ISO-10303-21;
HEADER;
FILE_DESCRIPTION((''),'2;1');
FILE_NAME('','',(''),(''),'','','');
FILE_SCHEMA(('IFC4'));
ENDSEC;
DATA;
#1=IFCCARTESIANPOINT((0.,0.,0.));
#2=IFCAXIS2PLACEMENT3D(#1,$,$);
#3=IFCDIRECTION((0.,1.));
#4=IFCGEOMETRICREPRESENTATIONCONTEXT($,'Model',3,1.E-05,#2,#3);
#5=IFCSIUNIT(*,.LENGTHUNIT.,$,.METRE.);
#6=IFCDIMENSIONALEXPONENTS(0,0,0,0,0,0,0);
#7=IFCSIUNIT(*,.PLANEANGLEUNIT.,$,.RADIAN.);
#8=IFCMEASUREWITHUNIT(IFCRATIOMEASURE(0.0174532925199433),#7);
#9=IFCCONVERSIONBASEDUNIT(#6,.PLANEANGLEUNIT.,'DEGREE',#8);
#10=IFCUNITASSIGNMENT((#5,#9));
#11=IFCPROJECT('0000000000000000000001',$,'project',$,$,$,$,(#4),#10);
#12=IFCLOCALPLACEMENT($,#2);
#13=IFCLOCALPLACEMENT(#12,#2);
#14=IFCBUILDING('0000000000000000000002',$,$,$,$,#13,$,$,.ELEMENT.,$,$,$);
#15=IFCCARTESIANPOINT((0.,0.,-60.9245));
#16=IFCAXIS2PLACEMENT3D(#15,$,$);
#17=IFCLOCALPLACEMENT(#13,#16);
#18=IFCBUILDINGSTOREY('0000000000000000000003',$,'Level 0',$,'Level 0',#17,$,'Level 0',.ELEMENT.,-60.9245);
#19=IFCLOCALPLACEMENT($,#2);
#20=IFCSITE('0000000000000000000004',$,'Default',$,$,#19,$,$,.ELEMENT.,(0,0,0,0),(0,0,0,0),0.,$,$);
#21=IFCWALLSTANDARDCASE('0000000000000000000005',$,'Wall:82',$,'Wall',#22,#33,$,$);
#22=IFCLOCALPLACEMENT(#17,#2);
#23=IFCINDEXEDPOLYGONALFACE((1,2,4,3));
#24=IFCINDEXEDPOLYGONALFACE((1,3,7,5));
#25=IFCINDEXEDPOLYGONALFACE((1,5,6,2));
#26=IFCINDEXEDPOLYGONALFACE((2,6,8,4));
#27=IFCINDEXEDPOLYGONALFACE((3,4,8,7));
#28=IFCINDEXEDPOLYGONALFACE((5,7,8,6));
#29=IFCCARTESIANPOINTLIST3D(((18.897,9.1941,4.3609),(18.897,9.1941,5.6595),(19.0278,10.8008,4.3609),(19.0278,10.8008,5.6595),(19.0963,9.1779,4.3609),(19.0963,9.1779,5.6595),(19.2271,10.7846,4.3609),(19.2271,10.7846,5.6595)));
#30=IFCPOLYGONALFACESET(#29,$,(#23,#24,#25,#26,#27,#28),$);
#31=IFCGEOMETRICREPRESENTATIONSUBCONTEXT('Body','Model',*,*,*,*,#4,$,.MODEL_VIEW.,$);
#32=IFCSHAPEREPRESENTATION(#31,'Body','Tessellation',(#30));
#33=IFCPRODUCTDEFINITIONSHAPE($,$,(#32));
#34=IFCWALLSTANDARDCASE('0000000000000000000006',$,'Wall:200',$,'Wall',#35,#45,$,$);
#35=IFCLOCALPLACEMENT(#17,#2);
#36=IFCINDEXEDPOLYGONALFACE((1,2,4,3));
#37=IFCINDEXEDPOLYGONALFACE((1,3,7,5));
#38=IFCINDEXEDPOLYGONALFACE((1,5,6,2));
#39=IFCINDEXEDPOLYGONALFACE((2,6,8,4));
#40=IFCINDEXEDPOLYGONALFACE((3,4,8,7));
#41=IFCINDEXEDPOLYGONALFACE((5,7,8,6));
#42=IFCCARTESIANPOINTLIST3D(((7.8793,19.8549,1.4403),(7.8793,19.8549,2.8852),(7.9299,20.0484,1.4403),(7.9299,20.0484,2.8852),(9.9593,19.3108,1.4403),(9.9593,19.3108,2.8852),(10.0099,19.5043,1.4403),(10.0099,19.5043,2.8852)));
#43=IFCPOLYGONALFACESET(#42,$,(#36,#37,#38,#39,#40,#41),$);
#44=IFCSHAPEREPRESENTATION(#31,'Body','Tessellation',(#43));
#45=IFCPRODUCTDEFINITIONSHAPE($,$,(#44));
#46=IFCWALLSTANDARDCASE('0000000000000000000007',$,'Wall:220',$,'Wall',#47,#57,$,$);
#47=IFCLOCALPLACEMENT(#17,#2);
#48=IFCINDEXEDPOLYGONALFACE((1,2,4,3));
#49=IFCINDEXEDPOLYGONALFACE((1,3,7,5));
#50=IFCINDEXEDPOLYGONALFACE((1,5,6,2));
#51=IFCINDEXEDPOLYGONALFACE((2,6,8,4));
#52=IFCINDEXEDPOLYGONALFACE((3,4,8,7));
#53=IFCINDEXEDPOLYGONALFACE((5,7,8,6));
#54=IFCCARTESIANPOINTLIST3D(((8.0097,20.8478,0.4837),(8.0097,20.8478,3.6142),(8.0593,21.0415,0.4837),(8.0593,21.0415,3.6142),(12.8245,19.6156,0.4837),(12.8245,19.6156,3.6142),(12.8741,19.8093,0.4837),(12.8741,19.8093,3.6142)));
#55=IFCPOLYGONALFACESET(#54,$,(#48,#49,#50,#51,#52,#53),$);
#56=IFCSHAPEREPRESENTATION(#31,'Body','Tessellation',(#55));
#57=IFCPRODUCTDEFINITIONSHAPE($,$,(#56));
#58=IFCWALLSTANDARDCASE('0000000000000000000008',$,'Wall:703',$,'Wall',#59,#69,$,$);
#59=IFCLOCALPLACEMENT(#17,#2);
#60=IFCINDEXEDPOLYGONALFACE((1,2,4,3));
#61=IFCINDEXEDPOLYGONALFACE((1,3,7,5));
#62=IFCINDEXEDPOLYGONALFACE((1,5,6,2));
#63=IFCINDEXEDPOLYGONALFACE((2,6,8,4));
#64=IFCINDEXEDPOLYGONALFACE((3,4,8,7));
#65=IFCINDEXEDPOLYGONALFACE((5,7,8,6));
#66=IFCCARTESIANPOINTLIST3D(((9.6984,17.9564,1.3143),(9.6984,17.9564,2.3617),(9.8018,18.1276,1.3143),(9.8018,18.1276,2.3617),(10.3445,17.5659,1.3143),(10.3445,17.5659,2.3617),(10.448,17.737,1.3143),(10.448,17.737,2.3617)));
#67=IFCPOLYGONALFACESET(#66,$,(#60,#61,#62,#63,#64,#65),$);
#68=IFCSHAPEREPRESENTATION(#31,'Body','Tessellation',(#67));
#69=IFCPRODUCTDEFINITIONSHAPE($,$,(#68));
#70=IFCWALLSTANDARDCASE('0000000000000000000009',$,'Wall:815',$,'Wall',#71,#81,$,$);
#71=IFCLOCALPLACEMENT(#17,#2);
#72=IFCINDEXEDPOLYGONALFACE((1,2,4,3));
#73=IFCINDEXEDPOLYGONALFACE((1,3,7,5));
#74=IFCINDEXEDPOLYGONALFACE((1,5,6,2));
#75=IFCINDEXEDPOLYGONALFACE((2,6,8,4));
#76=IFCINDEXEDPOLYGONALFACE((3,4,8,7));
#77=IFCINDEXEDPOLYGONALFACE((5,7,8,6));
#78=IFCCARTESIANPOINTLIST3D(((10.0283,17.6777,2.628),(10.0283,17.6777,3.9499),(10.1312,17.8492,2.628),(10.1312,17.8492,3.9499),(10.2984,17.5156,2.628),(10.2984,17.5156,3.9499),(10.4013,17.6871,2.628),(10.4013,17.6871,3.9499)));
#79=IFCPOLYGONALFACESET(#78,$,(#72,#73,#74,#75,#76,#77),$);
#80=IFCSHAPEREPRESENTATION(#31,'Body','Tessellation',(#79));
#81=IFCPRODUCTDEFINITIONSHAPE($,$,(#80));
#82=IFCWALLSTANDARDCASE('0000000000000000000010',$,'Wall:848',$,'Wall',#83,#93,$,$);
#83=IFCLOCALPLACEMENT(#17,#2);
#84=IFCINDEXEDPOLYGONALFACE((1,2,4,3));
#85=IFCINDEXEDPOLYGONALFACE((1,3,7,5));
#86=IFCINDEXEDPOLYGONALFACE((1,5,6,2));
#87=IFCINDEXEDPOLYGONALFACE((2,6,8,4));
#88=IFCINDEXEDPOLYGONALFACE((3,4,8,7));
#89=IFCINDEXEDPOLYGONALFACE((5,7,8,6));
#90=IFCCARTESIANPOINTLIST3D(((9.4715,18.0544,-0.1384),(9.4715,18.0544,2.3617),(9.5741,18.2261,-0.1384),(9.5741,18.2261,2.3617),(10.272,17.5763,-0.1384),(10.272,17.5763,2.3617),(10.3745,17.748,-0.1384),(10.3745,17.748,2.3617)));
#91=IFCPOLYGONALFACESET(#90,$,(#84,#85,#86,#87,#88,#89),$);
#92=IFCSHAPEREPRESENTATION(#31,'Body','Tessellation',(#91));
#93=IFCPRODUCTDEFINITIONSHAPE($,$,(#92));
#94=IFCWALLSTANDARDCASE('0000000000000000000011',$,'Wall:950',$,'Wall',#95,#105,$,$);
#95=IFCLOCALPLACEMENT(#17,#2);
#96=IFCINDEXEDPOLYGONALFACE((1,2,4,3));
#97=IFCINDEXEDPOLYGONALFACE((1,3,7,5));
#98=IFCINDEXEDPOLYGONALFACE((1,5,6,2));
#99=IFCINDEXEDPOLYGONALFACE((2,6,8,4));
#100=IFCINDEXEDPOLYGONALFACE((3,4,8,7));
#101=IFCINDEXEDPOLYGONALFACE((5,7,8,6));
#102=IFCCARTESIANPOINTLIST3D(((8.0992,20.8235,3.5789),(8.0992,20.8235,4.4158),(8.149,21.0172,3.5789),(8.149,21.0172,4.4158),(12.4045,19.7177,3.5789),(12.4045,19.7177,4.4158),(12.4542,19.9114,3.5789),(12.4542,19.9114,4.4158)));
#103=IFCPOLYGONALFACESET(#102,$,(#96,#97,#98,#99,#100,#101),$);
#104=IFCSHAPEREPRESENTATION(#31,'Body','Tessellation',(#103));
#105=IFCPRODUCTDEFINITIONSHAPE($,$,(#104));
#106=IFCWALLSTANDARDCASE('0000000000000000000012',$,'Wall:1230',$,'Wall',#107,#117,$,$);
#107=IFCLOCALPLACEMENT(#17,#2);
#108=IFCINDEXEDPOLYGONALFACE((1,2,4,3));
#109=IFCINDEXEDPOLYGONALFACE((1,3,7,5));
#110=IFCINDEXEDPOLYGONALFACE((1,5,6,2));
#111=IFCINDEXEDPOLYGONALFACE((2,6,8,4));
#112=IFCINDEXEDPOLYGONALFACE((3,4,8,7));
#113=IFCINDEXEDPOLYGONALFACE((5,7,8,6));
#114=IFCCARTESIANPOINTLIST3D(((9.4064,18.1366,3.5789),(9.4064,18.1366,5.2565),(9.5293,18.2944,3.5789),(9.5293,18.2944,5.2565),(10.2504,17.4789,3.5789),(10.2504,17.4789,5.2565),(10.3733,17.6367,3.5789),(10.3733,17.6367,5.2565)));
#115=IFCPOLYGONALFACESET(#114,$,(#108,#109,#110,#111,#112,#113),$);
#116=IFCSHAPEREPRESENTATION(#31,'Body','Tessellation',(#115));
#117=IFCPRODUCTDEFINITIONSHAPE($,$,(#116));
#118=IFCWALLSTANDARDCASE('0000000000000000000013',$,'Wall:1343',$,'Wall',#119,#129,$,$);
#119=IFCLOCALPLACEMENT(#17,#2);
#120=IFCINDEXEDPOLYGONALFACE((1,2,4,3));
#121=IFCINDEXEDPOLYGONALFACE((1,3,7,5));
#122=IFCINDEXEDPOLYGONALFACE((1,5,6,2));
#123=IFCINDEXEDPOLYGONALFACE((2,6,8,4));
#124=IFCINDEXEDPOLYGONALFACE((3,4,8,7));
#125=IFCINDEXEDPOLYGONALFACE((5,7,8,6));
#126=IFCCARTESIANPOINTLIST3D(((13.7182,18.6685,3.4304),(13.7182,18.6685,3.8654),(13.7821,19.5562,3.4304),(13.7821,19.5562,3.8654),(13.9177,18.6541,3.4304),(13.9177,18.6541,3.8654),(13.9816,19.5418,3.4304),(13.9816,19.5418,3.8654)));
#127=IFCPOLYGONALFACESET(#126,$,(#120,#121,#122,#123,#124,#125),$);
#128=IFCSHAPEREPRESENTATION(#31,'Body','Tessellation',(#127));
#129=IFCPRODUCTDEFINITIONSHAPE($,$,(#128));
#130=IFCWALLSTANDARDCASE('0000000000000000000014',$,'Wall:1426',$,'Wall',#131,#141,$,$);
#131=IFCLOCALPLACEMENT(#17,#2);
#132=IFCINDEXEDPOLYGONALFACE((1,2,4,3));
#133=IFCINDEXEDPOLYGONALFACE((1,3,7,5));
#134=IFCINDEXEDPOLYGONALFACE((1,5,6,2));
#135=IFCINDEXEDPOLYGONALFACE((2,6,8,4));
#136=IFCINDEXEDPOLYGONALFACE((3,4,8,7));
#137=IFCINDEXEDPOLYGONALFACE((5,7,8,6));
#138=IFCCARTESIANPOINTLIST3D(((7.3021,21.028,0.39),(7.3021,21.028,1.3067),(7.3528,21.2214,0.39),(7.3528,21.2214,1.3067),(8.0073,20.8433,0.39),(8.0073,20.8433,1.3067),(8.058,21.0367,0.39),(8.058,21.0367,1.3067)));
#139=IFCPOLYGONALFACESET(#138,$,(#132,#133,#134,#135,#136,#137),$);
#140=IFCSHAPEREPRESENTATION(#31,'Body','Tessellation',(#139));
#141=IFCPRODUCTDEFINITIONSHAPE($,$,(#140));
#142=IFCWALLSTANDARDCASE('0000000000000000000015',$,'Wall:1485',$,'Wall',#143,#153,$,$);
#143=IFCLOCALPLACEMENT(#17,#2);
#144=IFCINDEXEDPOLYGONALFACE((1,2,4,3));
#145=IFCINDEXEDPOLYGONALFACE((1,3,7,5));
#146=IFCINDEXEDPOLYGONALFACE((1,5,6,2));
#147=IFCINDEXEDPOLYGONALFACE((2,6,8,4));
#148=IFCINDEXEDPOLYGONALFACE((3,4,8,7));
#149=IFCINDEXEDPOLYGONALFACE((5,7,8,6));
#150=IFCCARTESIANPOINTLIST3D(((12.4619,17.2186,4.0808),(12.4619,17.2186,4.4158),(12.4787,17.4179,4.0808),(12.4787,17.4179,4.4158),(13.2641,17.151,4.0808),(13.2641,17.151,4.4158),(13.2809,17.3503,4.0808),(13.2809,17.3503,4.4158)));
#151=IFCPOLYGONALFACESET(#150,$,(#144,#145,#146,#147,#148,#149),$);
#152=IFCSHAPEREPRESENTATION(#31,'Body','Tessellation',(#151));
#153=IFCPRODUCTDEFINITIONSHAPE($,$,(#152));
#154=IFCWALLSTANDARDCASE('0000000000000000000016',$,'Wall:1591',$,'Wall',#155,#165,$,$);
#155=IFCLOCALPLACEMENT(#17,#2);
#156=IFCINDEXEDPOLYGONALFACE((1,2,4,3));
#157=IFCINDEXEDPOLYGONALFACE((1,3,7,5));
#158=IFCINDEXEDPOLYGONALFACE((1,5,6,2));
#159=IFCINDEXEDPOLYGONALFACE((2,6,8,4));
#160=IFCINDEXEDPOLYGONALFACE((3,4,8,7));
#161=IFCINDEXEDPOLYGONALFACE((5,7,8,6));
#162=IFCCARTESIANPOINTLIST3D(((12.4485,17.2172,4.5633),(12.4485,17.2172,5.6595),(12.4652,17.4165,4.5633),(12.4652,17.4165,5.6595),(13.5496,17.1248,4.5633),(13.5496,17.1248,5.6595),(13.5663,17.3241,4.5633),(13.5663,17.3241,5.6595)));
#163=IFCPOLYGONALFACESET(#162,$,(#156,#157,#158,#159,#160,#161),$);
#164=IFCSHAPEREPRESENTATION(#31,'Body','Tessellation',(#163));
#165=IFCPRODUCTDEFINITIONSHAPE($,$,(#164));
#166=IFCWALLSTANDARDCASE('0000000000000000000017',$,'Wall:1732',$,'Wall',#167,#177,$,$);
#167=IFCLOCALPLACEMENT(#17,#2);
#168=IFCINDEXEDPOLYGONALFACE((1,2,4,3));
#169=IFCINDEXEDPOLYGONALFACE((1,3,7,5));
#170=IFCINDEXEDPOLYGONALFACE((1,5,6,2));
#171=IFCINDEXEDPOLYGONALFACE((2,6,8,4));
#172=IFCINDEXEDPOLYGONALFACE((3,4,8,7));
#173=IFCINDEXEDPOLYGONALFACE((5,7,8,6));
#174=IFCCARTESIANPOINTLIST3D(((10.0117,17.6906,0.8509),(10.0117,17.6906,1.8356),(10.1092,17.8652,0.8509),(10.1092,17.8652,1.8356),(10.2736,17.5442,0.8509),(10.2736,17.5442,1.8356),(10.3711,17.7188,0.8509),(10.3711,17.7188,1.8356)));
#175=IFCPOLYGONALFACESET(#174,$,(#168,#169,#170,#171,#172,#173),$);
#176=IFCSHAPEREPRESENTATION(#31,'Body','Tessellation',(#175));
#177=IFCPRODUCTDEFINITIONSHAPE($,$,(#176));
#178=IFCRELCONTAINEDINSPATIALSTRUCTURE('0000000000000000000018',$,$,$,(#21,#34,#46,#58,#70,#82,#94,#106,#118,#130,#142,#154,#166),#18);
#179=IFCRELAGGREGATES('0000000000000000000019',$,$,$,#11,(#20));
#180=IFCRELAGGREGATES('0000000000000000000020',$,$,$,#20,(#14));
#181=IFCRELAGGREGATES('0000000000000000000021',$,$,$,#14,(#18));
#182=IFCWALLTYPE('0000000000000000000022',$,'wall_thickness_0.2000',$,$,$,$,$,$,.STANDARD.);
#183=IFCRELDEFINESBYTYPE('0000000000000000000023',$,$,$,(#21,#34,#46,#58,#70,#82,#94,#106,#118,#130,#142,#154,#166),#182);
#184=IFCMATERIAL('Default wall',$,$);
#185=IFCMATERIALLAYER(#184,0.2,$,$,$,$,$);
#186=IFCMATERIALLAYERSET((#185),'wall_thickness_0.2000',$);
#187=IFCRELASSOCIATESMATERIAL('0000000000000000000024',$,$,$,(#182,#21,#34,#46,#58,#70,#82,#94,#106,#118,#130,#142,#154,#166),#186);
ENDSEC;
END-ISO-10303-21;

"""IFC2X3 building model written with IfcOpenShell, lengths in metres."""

from ifc_helpers import new_model, entity, si_unit, converted_unit, direction, frame, origin, place, context, subcontext, project, spatial, polyline, outline, extrude, material, layer, layer_set, layer_usage, type_object, element, save


model = new_model("IFC2X3")

# Units and contexts
model_context = context("Model", 3, precision=1e-05, world=origin(), true_north=direction((0.0, 1.0)))
body_context = subcontext(model_context, "Body", "Model", "MODEL_VIEW")
ifc_project = project(units=[si_unit("LENGTHUNIT", "METRE"), converted_unit("PLANEANGLEUNIT", "DEGREE", entity("IfcRatioMeasure", 0.0174532925199433), si_unit("PLANEANGLEUNIT", "RADIAN"), dimensions=[0, 0, 0, 0, 0, 0, 0])], contexts=[model_context])

# Site, building, storey
site_placement = place(None, origin())
site = spatial("IfcSite", under=ifc_project, at=site_placement, Name="Default", CompositionType="ELEMENT", RefLatitude=(0, 0, 0, 0), RefLongitude=(0, 0, 0, 0), RefElevation=0.0)
placement_1 = place(None, origin())
building_placement = place(placement_1, origin())
building = spatial("IfcBuilding", under=site, at=building_placement, CompositionType="ELEMENT")
storey_placement = place(building_placement, frame((0.0, 0.0, -60.9245)))
storey = spatial("IfcBuildingStorey", under=building, at=storey_placement, Name="Level 0", ObjectType="Level 0", LongName="Level 0", CompositionType="ELEMENT", Elevation=-60.9245)

# Walls
ifc_material = material(Name="Default wall")
ifc_layer = layer(ifc_material, 0.2)
ifc_layer_set = layer_set([ifc_layer], Name="wall_thickness_0.2000")
ifc_layer_usage = layer_usage(ifc_layer_set, "AXIS2", "POSITIVE", -0.1)
wall_type = type_object("IfcWallType", Name="wall_thickness_0.2000", PredefinedType="STANDARD", material=ifc_layer_set)
placement_2 = place(building_placement, frame((0.0, 0.0, -56.5636)))
wall_1_placement = place(placement_2, frame((19.1274, 10.7927, 0.0), z_axis=(0.0, 0.0, 1.0), x_axis=(-0.081124, -0.996704, 0.0)))
element("IfcWallStandardCase", 1, at=wall_1_placement, inside=storey, type_object=wall_type, material=ifc_layer_usage, Name="Wall:82", ObjectType="Wall", context=body_context, shape_type="SweptSolid", body=[
    extrude(outline(polyline([(1.612, -0.1), (1.612, 0.1), (0.0, 0.1), (0.0, -0.1), (1.612, -0.1)])), origin(), (0.0, 0.0, 1.0), 1.2985),
])
placement_3 = place(building_placement, frame((0.0, 0.0, -59.4842)))
wall_2_placement = place(placement_3, frame((7.9046, 19.9517, 0.0), z_axis=(0.0, 0.0, 1.0), x_axis=(0.96744, -0.253101, 0.0)))
element("IfcWallStandardCase", 2, at=wall_2_placement, inside=storey, type_object=wall_type, material=ifc_layer_usage, Name="Wall:200", ObjectType="Wall", context=body_context, shape_type="SweptSolid", body=[
    extrude(outline(polyline([(2.15, -0.1), (2.15, 0.1), (0.0, 0.1), (0.0, -0.1), (2.15, -0.1)])), origin(), (0.0, 0.0, 1.0), 1.4449),
])
placement_4 = place(building_placement, frame((0.0, 0.0, -60.4408)))
wall_3_placement = place(placement_4, frame((8.0345, 20.9446, 0.0), z_axis=(0.0, 0.0, 1.0), x_axis=(0.96878, -0.247923, 0.0)))
element("IfcWallStandardCase", 3, at=wall_3_placement, inside=storey, type_object=wall_type, material=ifc_layer_usage, Name="Wall:220", ObjectType="Wall", context=body_context, shape_type="SweptSolid", body=[
    extrude(outline(polyline([(4.97, -0.1), (4.97, 0.1), (0.0, 0.1), (0.0, -0.1), (4.97, -0.1)])), origin(), (0.0, 0.0, 1.0), 3.1305),
])
placement_5 = place(building_placement, frame((0.0, 0.0, -59.6102)))
wall_4_placement = place(placement_5, frame((10.3963, 17.6515, 0.0), z_axis=(0.0, 0.0, 1.0), x_axis=(-0.85584, 0.51724, 0.0)))
element("IfcWallStandardCase", 4, at=wall_4_placement, inside=storey, type_object=wall_type, material=ifc_layer_usage, Name="Wall:703", ObjectType="Wall", context=body_context, shape_type="SweptSolid", body=[
    extrude(outline(polyline([(0.755, -0.1), (0.755, 0.1), (0.0, 0.1), (0.0, -0.1), (0.755, -0.1)])), origin(), (0.0, 0.0, 1.0), 1.0474),
])
placement_6 = place(building_placement, frame((0.0, 0.0, -58.2965)))
wall_5_placement = place(placement_6, frame((10.3499, 17.6013, 0.0), z_axis=(0.0, 0.0, 1.0), x_axis=(-0.857418, 0.514621, 0.0)))
element("IfcWallStandardCase", 5, at=wall_5_placement, inside=storey, type_object=wall_type, material=ifc_layer_usage, Name="Wall:815", ObjectType="Wall", context=body_context, shape_type="SweptSolid", body=[
    extrude(outline(polyline([(0.315, -0.1), (0.315, 0.1), (0.0, 0.1), (0.0, -0.1), (0.315, -0.1)])), origin(), (0.0, 0.0, 1.0), 1.3219),
])
placement_7 = place(building_placement, frame((0.0, 0.0, -61.0629)))
wall_6_placement = place(placement_7, frame((10.3233, 17.6621, 0.0), z_axis=(0.0, 0.0, 1.0), x_axis=(-0.858516, 0.512787, 0.0)))
element("IfcWallStandardCase", 6, at=wall_6_placement, inside=storey, type_object=wall_type, material=ifc_layer_usage, Name="Wall:848", ObjectType="Wall", context=body_context, shape_type="SweptSolid", body=[
    extrude(outline(polyline([(0.9324, -0.1), (0.9324, 0.1), (0.0, 0.1), (0.0, -0.1), (0.9324, -0.1)])), origin(), (0.0, 0.0, 1.0), 2.5001),
])
placement_8 = place(building_placement, frame((0.0, 0.0, -57.3456)))
wall_7_placement = place(placement_8, frame((8.1241, 20.9204, 0.0), z_axis=(0.0, 0.0, 1.0), x_axis=(0.968563, -0.248767, 0.0)))
element("IfcWallStandardCase", 7, at=wall_7_placement, inside=storey, type_object=wall_type, material=ifc_layer_usage, Name="Wall:950", ObjectType="Wall", context=body_context, shape_type="SweptSolid", body=[
    extrude(outline(polyline([(4.445, -0.1), (4.445, 0.1), (0.0, 0.1), (0.0, -0.1), (4.445, -0.1)])), origin(), (0.0, 0.0, 1.0), 0.8369),
])
placement_9 = place(building_placement, frame((0.0, 0.0, -57.3456)))
wall_8_placement = place(placement_9, frame((10.3119, 17.5578, 0.0), z_axis=(0.0, 0.0, 1.0), x_axis=(-0.78878, 0.614676, 0.0)))
element("IfcWallStandardCase", 8, at=wall_8_placement, inside=storey, type_object=wall_type, material=ifc_layer_usage, Name="Wall:1230", ObjectType="Wall", context=body_context, shape_type="SweptSolid", body=[
    extrude(outline(polyline([(1.07, -0.1), (1.07, 0.1), (0.0, 0.1), (0.0, -0.1), (1.07, -0.1)])), origin(), (0.0, 0.0, 1.0), 1.6776),
])
placement_10 = place(building_placement, frame((0.0, 0.0, -57.4941)))
wall_9_placement = place(placement_10, frame((13.8179, 18.6613, 0.0), z_axis=(0.0, 0.0, 1.0), x_axis=(0.071858, 0.997415, 0.0)))
element("IfcWallStandardCase", 9, at=wall_9_placement, inside=storey, type_object=wall_type, material=ifc_layer_usage, Name="Wall:1343", ObjectType="Wall", context=body_context, shape_type="SweptSolid", body=[
    extrude(outline(polyline([(0.89, -0.1), (0.89, 0.1), (0.0, 0.1), (0.0, -0.1), (0.89, -0.1)])), origin(), (0.0, 0.0, 1.0), 0.435),
])
placement_11 = place(building_placement, frame((0.0, 0.0, -60.5345)))
wall_10_placement = place(placement_11, frame((7.3274, 21.1247, 0.0), z_axis=(0.0, 0.0, 1.0), x_axis=(0.967376, -0.253345, 0.0)))
element("IfcWallStandardCase", 10, at=wall_10_placement, inside=storey, type_object=wall_type, material=ifc_layer_usage, Name="Wall:1426", ObjectType="Wall", context=body_context, shape_type="SweptSolid", body=[
    extrude(outline(polyline([(0.729, -0.1), (0.729, 0.1), (0.0, 0.1), (0.0, -0.1), (0.729, -0.1)])), origin(), (0.0, 0.0, 1.0), 0.9167),
])
placement_12 = place(building_placement, frame((0.0, 0.0, -56.8437)))
wall_11_placement = place(placement_12, frame((12.4703, 17.3183, 0.0), z_axis=(0.0, 0.0, 1.0), x_axis=(0.996465, -0.084013, 0.0)))
element("IfcWallStandardCase", 11, at=wall_11_placement, inside=storey, type_object=wall_type, material=ifc_layer_usage, Name="Wall:1485", ObjectType="Wall", context=body_context, shape_type="SweptSolid", body=[
    extrude(outline(polyline([(0.805, -0.1), (0.805, 0.1), (0.0, 0.1), (0.0, -0.1), (0.805, -0.1)])), origin(), (0.0, 0.0, 1.0), 0.335),
])
placement_13 = place(building_placement, frame((0.0, 0.0, -56.3612)))
wall_12_placement = place(placement_13, frame((13.558, 17.2244, 0.0), z_axis=(0.0, 0.0, 1.0), x_axis=(-0.996492, 0.083687, 0.0)))
element("IfcWallStandardCase", 12, at=wall_12_placement, inside=storey, type_object=wall_type, material=ifc_layer_usage, Name="Wall:1591", ObjectType="Wall", context=body_context, shape_type="SweptSolid", body=[
    extrude(outline(polyline([(1.105, -0.1), (1.105, 0.1), (0.0, 0.1), (0.0, -0.1), (1.105, -0.1)])), origin(), (0.0, 0.0, 1.0), 1.0962),
])
placement_14 = place(building_placement, frame((0.0, 0.0, -60.0736)))
wall_13_placement = place(placement_14, frame((10.3224, 17.6315, 0.0), z_axis=(0.0, 0.0, 1.0), x_axis=(-0.872981, 0.487754, 0.0)))
element("IfcWallStandardCase", 13, at=wall_13_placement, inside=storey, type_object=wall_type, material=ifc_layer_usage, Name="Wall:1732", ObjectType="Wall", context=body_context, shape_type="SweptSolid", body=[
    extrude(outline(polyline([(0.3, -0.1), (0.3, 0.1), (0.0, 0.1), (0.0, -0.1), (0.3, -0.1)])), origin(), (0.0, 0.0, 1.0), 0.9848),
])

save(model, "model.ifc")
